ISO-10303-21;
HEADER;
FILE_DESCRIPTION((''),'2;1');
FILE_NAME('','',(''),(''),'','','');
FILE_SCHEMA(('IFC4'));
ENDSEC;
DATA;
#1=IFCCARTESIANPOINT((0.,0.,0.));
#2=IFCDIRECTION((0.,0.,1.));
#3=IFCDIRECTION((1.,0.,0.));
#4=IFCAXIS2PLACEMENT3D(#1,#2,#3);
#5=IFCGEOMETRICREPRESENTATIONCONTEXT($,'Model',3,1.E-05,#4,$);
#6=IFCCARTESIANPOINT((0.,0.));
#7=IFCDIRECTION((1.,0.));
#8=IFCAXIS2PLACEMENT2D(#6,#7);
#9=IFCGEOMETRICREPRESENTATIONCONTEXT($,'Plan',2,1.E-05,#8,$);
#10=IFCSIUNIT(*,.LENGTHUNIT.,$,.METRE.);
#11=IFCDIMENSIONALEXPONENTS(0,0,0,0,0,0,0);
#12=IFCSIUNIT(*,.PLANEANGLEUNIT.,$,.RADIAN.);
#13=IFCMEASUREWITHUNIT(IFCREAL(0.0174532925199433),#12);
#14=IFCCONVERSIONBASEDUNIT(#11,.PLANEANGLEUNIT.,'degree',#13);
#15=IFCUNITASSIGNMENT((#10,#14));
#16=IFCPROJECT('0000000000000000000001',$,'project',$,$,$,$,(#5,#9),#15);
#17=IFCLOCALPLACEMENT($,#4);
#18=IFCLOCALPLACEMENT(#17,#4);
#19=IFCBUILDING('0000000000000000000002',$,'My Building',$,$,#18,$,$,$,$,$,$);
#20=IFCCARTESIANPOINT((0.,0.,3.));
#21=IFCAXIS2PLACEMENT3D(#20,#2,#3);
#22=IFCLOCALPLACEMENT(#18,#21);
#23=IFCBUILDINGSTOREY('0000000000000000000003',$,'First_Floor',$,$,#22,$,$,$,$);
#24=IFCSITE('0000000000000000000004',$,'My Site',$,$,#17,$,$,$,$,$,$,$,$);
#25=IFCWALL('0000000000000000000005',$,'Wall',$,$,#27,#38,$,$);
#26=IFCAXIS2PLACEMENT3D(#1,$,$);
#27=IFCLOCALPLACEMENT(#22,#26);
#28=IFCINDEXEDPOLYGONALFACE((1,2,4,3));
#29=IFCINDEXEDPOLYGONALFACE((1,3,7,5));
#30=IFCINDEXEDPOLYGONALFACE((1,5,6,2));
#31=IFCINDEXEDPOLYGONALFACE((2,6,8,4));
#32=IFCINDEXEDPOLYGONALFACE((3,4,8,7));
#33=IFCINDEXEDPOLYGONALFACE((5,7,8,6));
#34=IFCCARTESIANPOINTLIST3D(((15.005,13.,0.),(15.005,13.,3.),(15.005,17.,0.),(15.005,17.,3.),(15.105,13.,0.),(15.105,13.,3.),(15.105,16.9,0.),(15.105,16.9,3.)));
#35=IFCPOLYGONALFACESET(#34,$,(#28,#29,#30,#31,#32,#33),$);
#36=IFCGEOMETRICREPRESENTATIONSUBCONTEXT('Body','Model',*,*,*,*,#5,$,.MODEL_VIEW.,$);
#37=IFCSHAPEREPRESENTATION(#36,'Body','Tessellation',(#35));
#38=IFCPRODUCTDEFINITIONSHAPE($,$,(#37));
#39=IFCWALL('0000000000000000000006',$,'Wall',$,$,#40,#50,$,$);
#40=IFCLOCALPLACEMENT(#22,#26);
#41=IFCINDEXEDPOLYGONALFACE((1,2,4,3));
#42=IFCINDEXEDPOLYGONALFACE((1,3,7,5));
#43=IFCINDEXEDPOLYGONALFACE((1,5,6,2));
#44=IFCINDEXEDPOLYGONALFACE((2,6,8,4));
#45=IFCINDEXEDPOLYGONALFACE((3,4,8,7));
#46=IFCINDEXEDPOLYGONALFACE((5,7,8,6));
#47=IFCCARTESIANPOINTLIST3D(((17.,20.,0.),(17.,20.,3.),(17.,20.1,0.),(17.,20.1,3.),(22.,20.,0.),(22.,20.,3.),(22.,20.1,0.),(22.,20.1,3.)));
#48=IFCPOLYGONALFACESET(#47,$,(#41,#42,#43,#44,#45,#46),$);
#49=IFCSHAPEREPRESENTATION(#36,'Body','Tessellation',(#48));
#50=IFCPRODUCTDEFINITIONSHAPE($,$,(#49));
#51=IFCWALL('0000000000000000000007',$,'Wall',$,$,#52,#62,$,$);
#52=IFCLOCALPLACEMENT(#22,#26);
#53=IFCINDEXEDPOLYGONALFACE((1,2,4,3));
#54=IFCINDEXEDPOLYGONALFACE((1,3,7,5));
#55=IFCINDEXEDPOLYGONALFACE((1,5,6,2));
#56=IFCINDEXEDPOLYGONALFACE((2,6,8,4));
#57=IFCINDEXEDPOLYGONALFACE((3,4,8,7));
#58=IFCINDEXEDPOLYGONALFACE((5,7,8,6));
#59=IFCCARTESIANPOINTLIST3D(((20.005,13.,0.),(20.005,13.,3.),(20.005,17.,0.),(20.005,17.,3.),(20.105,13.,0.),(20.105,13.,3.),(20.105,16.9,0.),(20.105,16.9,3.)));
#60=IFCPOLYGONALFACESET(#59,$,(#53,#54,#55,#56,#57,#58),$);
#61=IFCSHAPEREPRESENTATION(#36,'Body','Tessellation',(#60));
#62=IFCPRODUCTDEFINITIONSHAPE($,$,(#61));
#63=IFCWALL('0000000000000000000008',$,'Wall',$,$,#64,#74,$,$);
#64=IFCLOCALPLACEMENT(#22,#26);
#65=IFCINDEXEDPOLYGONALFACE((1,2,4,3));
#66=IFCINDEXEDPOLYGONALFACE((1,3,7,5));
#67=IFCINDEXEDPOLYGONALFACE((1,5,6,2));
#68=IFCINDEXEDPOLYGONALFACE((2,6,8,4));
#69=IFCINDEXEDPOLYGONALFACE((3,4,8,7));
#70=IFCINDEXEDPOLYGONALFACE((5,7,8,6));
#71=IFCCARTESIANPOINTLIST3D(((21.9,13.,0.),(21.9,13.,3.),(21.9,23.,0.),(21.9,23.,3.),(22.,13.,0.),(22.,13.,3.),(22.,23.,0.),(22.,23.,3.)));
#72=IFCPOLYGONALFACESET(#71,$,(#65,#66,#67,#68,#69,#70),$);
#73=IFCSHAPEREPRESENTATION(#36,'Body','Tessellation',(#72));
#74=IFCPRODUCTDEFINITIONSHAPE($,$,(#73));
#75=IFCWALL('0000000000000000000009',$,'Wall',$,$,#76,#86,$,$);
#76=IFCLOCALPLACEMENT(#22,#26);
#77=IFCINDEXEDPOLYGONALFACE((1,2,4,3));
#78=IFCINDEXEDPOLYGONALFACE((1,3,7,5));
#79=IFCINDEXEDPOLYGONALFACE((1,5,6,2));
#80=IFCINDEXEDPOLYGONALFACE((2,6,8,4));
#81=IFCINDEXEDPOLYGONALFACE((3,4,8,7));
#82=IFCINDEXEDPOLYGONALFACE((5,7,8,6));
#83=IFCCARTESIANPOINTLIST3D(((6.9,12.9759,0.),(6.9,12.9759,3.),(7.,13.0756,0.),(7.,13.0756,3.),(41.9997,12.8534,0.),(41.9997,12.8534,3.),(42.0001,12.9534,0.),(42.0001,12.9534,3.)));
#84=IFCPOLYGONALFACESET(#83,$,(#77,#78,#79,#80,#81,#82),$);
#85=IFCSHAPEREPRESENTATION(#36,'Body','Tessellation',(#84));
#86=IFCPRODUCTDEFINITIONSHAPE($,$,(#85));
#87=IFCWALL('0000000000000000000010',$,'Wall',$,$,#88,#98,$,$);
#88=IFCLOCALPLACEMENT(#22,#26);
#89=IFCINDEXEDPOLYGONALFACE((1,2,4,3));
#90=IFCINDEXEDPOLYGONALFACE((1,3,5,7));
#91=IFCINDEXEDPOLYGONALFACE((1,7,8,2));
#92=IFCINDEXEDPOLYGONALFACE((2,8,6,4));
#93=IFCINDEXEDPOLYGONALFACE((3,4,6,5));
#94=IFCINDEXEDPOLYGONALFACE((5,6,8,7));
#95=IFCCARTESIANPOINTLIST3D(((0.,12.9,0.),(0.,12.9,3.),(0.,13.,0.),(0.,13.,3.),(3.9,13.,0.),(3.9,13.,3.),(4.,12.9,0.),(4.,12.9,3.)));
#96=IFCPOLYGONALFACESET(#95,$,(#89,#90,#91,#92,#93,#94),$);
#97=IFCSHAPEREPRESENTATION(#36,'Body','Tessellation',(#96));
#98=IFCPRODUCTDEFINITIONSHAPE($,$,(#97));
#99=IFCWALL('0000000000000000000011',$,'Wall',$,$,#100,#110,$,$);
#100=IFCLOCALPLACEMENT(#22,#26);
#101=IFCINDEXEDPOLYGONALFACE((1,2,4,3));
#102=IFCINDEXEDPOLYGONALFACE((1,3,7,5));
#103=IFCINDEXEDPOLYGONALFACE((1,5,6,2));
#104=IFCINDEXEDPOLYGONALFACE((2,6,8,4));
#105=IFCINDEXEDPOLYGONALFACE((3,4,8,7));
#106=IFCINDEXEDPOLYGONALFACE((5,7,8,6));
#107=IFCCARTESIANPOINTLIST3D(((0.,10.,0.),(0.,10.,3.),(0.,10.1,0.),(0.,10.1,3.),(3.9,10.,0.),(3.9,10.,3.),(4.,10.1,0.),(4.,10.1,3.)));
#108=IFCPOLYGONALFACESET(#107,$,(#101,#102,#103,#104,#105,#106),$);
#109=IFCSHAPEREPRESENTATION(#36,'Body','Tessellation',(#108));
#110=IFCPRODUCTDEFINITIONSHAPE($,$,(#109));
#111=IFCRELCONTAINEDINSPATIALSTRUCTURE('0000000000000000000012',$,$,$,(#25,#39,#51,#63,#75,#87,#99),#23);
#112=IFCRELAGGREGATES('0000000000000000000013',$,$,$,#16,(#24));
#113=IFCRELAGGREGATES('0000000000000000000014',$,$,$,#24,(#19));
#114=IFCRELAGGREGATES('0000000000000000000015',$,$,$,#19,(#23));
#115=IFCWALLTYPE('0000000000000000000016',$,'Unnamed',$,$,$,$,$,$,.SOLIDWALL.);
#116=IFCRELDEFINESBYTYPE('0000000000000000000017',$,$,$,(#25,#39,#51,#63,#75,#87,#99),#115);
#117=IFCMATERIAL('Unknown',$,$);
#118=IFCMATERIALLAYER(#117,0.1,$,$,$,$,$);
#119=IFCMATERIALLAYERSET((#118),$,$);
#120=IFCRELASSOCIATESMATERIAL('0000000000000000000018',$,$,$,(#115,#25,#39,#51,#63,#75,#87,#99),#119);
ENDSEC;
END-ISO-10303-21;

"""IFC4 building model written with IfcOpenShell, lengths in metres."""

from ifc_helpers import new_model, entity, si_unit, converted_unit, frame, origin_with_axes, origin_2d_with_axis, place, context, subcontext, project, spatial, line, indexed_curve, outline, extrude, material, layer, layer_set, layer_usage, type_object, element, save


model = new_model("IFC4")

# Units and contexts
model_context = context("Model", 3, precision=1e-05, world=origin_with_axes())
plan_context = context("Plan", 2, precision=1e-05, world=origin_2d_with_axis())
body_context = subcontext(model_context, "Body", "Model", "MODEL_VIEW")
ifc_project = project(units=[si_unit("LENGTHUNIT", "METRE"), converted_unit("PLANEANGLEUNIT", "degree", entity("IfcReal", 0.0174532925199433), si_unit("PLANEANGLEUNIT", "RADIAN"), dimensions=[0, 0, 0, 0, 0, 0, 0])], contexts=[model_context, plan_context])

# Site, building, storey
site_placement = place(None, origin_with_axes())
site = spatial("IfcSite", under=ifc_project, at=site_placement, Name="My Site")
building_placement = place(site_placement, origin_with_axes())
building = spatial("IfcBuilding", under=site, at=building_placement, Name="My Building")
storey_placement = place(building_placement, frame((0.0, 0.0, 3.0), z_axis=(0.0, 0.0, 1.0), x_axis=(1.0, 0.0, 0.0)))
storey = spatial("IfcBuildingStorey", under=building, at=storey_placement, Name="First_Floor")

# Shared definitions
ifc_material = material(Name="Unknown")

# Walls
ifc_layer_1 = layer(ifc_material, 0.1)
ifc_layer_set_1 = layer_set([ifc_layer_1])
wall_type = type_object("IfcWallType", Name="Unnamed", PredefinedType="SOLIDWALL", material=ifc_layer_set_1)
ifc_layer_usage_1 = layer_usage(ifc_layer_set_1, "AXIS2", "POSITIVE", 0.0)
wall_1_placement = place(storey_placement, frame((15.005, 17.0, 0.0), z_axis=(0.0, 0.0, 1.0), x_axis=(0.0, -1.0, 0.0)))
element("IfcWall", 1, at=wall_1_placement, inside=storey, type_object=wall_type, material=ifc_layer_usage_1, Name="Wall", context=body_context, shape_type="SweptSolid", body=[
    extrude(outline(indexed_curve([(0.0, 0.0), (0.1, 0.1), (4.0, 0.1), (4.0, 0.0)], segments=[line(1, 2, 3, 4, 1)])), origin_with_axes(), (0.0, 0.0, 1.0), 3.0),
])
ifc_layer_usage_2 = layer_usage(ifc_layer_set_1, "AXIS2", "POSITIVE", 0.0)
wall_2_placement = place(storey_placement, frame((17.0, 20.0, 0.0), z_axis=(0.0, 0.0, 1.0), x_axis=(1.0, 0.0, 0.0)))
element("IfcWall", 2, at=wall_2_placement, inside=storey, type_object=wall_type, material=ifc_layer_usage_2, Name="Wall", context=body_context, shape_type="SweptSolid", body=[
    extrude(outline(indexed_curve([(0.0, 0.0), (0.0, 0.1), (5.0, 0.1), (5.0, 0.0)], segments=[line(1, 2, 3, 4, 1)])), origin_with_axes(), (0.0, 0.0, 1.0), 3.0),
])
ifc_layer_usage_3 = layer_usage(ifc_layer_set_1, "AXIS2", "POSITIVE", 0.0)
wall_3_placement = place(storey_placement, frame((20.005, 17.0, 0.0), z_axis=(0.0, 0.0, 1.0), x_axis=(0.0, -1.0, 0.0)))
element("IfcWall", 3, at=wall_3_placement, inside=storey, type_object=wall_type, material=ifc_layer_usage_3, Name="Wall", context=body_context, shape_type="SweptSolid", body=[
    extrude(outline(indexed_curve([(0.0, 0.0), (0.1, 0.1), (4.0, 0.1), (4.0, 0.0)], segments=[line(1, 2, 3, 4, 1)])), origin_with_axes(), (0.0, 0.0, 1.0), 3.0),
])
ifc_layer_usage_4 = layer_usage(ifc_layer_set_1, "AXIS2", "POSITIVE", 0.0)
wall_4_placement = place(storey_placement, frame((21.9, 23.0, 0.0), z_axis=(0.0, 0.0, 1.0), x_axis=(0.0, -1.0, 0.0)))
element("IfcWall", 4, at=wall_4_placement, inside=storey, type_object=wall_type, material=ifc_layer_usage_4, Name="Wall", context=body_context, shape_type="SweptSolid", body=[
    extrude(outline(indexed_curve([(0.0, 0.0), (0.0, 0.1), (10.0, 0.1), (10.0, 0.0)], segments=[line(1, 2, 3, 4, 1)])), origin_with_axes(), (0.0, 0.0, 1.0), 3.0),
])
ifc_layer_usage_5 = layer_usage(ifc_layer_set_1, "AXIS2", "POSITIVE", 0.0)
wall_5_placement = place(storey_placement, frame((6.9, 12.9759, 0.0), z_axis=(0.0, 0.0, 1.0), x_axis=(0.999994, -0.003491, 0.0)))
element("IfcWall", 5, at=wall_5_placement, inside=storey, type_object=wall_type, material=ifc_layer_usage_5, Name="Wall", context=body_context, shape_type="SweptSolid", body=[
    extrude(outline(indexed_curve([(0.0, 0.0), (0.0997, 0.1), (35.1, 0.1), (35.1, 0.0)], segments=[line(1, 2, 3, 4, 1)])), origin_with_axes(), (0.0, 0.0, 1.0), 3.0),
])
ifc_layer_usage_6 = layer_usage(ifc_layer_set_1, "AXIS2", "POSITIVE", 0.0)
wall_6_placement = place(storey_placement, frame((3.9, 13.0, 0.0), z_axis=(0.0, 0.0, 1.0), x_axis=(-1.0, 0.0, 0.0)))
element("IfcWall", 6, at=wall_6_placement, inside=storey, type_object=wall_type, material=ifc_layer_usage_6, Name="Wall", context=body_context, shape_type="SweptSolid", body=[
    extrude(outline(indexed_curve([(0.0, 0.0), (-0.1, 0.1), (3.9, 0.1), (3.9, 0.0)], segments=[line(1, 2, 3, 4, 1)])), origin_with_axes(), (0.0, 0.0, 1.0), 3.0),
])
ifc_layer_usage_7 = layer_usage(ifc_layer_set_1, "AXIS2", "POSITIVE", 0.0)
wall_7_placement = place(storey_placement, frame((3.9, 10.1, 0.0), z_axis=(0.0, 0.0, 1.0), x_axis=(-1.0, 0.0, 0.0)))
element("IfcWall", 7, at=wall_7_placement, inside=storey, type_object=wall_type, material=ifc_layer_usage_7, Name="Wall", context=body_context, shape_type="SweptSolid", body=[
    extrude(outline(indexed_curve([(-0.1, 0.0), (0.0, 0.1), (3.9, 0.1), (3.9, 0.0)], segments=[line(1, 2, 3, 4, 1)])), origin_with_axes(), (0.0, 0.0, 1.0), 3.0),
])

save(model, "model.ifc")
